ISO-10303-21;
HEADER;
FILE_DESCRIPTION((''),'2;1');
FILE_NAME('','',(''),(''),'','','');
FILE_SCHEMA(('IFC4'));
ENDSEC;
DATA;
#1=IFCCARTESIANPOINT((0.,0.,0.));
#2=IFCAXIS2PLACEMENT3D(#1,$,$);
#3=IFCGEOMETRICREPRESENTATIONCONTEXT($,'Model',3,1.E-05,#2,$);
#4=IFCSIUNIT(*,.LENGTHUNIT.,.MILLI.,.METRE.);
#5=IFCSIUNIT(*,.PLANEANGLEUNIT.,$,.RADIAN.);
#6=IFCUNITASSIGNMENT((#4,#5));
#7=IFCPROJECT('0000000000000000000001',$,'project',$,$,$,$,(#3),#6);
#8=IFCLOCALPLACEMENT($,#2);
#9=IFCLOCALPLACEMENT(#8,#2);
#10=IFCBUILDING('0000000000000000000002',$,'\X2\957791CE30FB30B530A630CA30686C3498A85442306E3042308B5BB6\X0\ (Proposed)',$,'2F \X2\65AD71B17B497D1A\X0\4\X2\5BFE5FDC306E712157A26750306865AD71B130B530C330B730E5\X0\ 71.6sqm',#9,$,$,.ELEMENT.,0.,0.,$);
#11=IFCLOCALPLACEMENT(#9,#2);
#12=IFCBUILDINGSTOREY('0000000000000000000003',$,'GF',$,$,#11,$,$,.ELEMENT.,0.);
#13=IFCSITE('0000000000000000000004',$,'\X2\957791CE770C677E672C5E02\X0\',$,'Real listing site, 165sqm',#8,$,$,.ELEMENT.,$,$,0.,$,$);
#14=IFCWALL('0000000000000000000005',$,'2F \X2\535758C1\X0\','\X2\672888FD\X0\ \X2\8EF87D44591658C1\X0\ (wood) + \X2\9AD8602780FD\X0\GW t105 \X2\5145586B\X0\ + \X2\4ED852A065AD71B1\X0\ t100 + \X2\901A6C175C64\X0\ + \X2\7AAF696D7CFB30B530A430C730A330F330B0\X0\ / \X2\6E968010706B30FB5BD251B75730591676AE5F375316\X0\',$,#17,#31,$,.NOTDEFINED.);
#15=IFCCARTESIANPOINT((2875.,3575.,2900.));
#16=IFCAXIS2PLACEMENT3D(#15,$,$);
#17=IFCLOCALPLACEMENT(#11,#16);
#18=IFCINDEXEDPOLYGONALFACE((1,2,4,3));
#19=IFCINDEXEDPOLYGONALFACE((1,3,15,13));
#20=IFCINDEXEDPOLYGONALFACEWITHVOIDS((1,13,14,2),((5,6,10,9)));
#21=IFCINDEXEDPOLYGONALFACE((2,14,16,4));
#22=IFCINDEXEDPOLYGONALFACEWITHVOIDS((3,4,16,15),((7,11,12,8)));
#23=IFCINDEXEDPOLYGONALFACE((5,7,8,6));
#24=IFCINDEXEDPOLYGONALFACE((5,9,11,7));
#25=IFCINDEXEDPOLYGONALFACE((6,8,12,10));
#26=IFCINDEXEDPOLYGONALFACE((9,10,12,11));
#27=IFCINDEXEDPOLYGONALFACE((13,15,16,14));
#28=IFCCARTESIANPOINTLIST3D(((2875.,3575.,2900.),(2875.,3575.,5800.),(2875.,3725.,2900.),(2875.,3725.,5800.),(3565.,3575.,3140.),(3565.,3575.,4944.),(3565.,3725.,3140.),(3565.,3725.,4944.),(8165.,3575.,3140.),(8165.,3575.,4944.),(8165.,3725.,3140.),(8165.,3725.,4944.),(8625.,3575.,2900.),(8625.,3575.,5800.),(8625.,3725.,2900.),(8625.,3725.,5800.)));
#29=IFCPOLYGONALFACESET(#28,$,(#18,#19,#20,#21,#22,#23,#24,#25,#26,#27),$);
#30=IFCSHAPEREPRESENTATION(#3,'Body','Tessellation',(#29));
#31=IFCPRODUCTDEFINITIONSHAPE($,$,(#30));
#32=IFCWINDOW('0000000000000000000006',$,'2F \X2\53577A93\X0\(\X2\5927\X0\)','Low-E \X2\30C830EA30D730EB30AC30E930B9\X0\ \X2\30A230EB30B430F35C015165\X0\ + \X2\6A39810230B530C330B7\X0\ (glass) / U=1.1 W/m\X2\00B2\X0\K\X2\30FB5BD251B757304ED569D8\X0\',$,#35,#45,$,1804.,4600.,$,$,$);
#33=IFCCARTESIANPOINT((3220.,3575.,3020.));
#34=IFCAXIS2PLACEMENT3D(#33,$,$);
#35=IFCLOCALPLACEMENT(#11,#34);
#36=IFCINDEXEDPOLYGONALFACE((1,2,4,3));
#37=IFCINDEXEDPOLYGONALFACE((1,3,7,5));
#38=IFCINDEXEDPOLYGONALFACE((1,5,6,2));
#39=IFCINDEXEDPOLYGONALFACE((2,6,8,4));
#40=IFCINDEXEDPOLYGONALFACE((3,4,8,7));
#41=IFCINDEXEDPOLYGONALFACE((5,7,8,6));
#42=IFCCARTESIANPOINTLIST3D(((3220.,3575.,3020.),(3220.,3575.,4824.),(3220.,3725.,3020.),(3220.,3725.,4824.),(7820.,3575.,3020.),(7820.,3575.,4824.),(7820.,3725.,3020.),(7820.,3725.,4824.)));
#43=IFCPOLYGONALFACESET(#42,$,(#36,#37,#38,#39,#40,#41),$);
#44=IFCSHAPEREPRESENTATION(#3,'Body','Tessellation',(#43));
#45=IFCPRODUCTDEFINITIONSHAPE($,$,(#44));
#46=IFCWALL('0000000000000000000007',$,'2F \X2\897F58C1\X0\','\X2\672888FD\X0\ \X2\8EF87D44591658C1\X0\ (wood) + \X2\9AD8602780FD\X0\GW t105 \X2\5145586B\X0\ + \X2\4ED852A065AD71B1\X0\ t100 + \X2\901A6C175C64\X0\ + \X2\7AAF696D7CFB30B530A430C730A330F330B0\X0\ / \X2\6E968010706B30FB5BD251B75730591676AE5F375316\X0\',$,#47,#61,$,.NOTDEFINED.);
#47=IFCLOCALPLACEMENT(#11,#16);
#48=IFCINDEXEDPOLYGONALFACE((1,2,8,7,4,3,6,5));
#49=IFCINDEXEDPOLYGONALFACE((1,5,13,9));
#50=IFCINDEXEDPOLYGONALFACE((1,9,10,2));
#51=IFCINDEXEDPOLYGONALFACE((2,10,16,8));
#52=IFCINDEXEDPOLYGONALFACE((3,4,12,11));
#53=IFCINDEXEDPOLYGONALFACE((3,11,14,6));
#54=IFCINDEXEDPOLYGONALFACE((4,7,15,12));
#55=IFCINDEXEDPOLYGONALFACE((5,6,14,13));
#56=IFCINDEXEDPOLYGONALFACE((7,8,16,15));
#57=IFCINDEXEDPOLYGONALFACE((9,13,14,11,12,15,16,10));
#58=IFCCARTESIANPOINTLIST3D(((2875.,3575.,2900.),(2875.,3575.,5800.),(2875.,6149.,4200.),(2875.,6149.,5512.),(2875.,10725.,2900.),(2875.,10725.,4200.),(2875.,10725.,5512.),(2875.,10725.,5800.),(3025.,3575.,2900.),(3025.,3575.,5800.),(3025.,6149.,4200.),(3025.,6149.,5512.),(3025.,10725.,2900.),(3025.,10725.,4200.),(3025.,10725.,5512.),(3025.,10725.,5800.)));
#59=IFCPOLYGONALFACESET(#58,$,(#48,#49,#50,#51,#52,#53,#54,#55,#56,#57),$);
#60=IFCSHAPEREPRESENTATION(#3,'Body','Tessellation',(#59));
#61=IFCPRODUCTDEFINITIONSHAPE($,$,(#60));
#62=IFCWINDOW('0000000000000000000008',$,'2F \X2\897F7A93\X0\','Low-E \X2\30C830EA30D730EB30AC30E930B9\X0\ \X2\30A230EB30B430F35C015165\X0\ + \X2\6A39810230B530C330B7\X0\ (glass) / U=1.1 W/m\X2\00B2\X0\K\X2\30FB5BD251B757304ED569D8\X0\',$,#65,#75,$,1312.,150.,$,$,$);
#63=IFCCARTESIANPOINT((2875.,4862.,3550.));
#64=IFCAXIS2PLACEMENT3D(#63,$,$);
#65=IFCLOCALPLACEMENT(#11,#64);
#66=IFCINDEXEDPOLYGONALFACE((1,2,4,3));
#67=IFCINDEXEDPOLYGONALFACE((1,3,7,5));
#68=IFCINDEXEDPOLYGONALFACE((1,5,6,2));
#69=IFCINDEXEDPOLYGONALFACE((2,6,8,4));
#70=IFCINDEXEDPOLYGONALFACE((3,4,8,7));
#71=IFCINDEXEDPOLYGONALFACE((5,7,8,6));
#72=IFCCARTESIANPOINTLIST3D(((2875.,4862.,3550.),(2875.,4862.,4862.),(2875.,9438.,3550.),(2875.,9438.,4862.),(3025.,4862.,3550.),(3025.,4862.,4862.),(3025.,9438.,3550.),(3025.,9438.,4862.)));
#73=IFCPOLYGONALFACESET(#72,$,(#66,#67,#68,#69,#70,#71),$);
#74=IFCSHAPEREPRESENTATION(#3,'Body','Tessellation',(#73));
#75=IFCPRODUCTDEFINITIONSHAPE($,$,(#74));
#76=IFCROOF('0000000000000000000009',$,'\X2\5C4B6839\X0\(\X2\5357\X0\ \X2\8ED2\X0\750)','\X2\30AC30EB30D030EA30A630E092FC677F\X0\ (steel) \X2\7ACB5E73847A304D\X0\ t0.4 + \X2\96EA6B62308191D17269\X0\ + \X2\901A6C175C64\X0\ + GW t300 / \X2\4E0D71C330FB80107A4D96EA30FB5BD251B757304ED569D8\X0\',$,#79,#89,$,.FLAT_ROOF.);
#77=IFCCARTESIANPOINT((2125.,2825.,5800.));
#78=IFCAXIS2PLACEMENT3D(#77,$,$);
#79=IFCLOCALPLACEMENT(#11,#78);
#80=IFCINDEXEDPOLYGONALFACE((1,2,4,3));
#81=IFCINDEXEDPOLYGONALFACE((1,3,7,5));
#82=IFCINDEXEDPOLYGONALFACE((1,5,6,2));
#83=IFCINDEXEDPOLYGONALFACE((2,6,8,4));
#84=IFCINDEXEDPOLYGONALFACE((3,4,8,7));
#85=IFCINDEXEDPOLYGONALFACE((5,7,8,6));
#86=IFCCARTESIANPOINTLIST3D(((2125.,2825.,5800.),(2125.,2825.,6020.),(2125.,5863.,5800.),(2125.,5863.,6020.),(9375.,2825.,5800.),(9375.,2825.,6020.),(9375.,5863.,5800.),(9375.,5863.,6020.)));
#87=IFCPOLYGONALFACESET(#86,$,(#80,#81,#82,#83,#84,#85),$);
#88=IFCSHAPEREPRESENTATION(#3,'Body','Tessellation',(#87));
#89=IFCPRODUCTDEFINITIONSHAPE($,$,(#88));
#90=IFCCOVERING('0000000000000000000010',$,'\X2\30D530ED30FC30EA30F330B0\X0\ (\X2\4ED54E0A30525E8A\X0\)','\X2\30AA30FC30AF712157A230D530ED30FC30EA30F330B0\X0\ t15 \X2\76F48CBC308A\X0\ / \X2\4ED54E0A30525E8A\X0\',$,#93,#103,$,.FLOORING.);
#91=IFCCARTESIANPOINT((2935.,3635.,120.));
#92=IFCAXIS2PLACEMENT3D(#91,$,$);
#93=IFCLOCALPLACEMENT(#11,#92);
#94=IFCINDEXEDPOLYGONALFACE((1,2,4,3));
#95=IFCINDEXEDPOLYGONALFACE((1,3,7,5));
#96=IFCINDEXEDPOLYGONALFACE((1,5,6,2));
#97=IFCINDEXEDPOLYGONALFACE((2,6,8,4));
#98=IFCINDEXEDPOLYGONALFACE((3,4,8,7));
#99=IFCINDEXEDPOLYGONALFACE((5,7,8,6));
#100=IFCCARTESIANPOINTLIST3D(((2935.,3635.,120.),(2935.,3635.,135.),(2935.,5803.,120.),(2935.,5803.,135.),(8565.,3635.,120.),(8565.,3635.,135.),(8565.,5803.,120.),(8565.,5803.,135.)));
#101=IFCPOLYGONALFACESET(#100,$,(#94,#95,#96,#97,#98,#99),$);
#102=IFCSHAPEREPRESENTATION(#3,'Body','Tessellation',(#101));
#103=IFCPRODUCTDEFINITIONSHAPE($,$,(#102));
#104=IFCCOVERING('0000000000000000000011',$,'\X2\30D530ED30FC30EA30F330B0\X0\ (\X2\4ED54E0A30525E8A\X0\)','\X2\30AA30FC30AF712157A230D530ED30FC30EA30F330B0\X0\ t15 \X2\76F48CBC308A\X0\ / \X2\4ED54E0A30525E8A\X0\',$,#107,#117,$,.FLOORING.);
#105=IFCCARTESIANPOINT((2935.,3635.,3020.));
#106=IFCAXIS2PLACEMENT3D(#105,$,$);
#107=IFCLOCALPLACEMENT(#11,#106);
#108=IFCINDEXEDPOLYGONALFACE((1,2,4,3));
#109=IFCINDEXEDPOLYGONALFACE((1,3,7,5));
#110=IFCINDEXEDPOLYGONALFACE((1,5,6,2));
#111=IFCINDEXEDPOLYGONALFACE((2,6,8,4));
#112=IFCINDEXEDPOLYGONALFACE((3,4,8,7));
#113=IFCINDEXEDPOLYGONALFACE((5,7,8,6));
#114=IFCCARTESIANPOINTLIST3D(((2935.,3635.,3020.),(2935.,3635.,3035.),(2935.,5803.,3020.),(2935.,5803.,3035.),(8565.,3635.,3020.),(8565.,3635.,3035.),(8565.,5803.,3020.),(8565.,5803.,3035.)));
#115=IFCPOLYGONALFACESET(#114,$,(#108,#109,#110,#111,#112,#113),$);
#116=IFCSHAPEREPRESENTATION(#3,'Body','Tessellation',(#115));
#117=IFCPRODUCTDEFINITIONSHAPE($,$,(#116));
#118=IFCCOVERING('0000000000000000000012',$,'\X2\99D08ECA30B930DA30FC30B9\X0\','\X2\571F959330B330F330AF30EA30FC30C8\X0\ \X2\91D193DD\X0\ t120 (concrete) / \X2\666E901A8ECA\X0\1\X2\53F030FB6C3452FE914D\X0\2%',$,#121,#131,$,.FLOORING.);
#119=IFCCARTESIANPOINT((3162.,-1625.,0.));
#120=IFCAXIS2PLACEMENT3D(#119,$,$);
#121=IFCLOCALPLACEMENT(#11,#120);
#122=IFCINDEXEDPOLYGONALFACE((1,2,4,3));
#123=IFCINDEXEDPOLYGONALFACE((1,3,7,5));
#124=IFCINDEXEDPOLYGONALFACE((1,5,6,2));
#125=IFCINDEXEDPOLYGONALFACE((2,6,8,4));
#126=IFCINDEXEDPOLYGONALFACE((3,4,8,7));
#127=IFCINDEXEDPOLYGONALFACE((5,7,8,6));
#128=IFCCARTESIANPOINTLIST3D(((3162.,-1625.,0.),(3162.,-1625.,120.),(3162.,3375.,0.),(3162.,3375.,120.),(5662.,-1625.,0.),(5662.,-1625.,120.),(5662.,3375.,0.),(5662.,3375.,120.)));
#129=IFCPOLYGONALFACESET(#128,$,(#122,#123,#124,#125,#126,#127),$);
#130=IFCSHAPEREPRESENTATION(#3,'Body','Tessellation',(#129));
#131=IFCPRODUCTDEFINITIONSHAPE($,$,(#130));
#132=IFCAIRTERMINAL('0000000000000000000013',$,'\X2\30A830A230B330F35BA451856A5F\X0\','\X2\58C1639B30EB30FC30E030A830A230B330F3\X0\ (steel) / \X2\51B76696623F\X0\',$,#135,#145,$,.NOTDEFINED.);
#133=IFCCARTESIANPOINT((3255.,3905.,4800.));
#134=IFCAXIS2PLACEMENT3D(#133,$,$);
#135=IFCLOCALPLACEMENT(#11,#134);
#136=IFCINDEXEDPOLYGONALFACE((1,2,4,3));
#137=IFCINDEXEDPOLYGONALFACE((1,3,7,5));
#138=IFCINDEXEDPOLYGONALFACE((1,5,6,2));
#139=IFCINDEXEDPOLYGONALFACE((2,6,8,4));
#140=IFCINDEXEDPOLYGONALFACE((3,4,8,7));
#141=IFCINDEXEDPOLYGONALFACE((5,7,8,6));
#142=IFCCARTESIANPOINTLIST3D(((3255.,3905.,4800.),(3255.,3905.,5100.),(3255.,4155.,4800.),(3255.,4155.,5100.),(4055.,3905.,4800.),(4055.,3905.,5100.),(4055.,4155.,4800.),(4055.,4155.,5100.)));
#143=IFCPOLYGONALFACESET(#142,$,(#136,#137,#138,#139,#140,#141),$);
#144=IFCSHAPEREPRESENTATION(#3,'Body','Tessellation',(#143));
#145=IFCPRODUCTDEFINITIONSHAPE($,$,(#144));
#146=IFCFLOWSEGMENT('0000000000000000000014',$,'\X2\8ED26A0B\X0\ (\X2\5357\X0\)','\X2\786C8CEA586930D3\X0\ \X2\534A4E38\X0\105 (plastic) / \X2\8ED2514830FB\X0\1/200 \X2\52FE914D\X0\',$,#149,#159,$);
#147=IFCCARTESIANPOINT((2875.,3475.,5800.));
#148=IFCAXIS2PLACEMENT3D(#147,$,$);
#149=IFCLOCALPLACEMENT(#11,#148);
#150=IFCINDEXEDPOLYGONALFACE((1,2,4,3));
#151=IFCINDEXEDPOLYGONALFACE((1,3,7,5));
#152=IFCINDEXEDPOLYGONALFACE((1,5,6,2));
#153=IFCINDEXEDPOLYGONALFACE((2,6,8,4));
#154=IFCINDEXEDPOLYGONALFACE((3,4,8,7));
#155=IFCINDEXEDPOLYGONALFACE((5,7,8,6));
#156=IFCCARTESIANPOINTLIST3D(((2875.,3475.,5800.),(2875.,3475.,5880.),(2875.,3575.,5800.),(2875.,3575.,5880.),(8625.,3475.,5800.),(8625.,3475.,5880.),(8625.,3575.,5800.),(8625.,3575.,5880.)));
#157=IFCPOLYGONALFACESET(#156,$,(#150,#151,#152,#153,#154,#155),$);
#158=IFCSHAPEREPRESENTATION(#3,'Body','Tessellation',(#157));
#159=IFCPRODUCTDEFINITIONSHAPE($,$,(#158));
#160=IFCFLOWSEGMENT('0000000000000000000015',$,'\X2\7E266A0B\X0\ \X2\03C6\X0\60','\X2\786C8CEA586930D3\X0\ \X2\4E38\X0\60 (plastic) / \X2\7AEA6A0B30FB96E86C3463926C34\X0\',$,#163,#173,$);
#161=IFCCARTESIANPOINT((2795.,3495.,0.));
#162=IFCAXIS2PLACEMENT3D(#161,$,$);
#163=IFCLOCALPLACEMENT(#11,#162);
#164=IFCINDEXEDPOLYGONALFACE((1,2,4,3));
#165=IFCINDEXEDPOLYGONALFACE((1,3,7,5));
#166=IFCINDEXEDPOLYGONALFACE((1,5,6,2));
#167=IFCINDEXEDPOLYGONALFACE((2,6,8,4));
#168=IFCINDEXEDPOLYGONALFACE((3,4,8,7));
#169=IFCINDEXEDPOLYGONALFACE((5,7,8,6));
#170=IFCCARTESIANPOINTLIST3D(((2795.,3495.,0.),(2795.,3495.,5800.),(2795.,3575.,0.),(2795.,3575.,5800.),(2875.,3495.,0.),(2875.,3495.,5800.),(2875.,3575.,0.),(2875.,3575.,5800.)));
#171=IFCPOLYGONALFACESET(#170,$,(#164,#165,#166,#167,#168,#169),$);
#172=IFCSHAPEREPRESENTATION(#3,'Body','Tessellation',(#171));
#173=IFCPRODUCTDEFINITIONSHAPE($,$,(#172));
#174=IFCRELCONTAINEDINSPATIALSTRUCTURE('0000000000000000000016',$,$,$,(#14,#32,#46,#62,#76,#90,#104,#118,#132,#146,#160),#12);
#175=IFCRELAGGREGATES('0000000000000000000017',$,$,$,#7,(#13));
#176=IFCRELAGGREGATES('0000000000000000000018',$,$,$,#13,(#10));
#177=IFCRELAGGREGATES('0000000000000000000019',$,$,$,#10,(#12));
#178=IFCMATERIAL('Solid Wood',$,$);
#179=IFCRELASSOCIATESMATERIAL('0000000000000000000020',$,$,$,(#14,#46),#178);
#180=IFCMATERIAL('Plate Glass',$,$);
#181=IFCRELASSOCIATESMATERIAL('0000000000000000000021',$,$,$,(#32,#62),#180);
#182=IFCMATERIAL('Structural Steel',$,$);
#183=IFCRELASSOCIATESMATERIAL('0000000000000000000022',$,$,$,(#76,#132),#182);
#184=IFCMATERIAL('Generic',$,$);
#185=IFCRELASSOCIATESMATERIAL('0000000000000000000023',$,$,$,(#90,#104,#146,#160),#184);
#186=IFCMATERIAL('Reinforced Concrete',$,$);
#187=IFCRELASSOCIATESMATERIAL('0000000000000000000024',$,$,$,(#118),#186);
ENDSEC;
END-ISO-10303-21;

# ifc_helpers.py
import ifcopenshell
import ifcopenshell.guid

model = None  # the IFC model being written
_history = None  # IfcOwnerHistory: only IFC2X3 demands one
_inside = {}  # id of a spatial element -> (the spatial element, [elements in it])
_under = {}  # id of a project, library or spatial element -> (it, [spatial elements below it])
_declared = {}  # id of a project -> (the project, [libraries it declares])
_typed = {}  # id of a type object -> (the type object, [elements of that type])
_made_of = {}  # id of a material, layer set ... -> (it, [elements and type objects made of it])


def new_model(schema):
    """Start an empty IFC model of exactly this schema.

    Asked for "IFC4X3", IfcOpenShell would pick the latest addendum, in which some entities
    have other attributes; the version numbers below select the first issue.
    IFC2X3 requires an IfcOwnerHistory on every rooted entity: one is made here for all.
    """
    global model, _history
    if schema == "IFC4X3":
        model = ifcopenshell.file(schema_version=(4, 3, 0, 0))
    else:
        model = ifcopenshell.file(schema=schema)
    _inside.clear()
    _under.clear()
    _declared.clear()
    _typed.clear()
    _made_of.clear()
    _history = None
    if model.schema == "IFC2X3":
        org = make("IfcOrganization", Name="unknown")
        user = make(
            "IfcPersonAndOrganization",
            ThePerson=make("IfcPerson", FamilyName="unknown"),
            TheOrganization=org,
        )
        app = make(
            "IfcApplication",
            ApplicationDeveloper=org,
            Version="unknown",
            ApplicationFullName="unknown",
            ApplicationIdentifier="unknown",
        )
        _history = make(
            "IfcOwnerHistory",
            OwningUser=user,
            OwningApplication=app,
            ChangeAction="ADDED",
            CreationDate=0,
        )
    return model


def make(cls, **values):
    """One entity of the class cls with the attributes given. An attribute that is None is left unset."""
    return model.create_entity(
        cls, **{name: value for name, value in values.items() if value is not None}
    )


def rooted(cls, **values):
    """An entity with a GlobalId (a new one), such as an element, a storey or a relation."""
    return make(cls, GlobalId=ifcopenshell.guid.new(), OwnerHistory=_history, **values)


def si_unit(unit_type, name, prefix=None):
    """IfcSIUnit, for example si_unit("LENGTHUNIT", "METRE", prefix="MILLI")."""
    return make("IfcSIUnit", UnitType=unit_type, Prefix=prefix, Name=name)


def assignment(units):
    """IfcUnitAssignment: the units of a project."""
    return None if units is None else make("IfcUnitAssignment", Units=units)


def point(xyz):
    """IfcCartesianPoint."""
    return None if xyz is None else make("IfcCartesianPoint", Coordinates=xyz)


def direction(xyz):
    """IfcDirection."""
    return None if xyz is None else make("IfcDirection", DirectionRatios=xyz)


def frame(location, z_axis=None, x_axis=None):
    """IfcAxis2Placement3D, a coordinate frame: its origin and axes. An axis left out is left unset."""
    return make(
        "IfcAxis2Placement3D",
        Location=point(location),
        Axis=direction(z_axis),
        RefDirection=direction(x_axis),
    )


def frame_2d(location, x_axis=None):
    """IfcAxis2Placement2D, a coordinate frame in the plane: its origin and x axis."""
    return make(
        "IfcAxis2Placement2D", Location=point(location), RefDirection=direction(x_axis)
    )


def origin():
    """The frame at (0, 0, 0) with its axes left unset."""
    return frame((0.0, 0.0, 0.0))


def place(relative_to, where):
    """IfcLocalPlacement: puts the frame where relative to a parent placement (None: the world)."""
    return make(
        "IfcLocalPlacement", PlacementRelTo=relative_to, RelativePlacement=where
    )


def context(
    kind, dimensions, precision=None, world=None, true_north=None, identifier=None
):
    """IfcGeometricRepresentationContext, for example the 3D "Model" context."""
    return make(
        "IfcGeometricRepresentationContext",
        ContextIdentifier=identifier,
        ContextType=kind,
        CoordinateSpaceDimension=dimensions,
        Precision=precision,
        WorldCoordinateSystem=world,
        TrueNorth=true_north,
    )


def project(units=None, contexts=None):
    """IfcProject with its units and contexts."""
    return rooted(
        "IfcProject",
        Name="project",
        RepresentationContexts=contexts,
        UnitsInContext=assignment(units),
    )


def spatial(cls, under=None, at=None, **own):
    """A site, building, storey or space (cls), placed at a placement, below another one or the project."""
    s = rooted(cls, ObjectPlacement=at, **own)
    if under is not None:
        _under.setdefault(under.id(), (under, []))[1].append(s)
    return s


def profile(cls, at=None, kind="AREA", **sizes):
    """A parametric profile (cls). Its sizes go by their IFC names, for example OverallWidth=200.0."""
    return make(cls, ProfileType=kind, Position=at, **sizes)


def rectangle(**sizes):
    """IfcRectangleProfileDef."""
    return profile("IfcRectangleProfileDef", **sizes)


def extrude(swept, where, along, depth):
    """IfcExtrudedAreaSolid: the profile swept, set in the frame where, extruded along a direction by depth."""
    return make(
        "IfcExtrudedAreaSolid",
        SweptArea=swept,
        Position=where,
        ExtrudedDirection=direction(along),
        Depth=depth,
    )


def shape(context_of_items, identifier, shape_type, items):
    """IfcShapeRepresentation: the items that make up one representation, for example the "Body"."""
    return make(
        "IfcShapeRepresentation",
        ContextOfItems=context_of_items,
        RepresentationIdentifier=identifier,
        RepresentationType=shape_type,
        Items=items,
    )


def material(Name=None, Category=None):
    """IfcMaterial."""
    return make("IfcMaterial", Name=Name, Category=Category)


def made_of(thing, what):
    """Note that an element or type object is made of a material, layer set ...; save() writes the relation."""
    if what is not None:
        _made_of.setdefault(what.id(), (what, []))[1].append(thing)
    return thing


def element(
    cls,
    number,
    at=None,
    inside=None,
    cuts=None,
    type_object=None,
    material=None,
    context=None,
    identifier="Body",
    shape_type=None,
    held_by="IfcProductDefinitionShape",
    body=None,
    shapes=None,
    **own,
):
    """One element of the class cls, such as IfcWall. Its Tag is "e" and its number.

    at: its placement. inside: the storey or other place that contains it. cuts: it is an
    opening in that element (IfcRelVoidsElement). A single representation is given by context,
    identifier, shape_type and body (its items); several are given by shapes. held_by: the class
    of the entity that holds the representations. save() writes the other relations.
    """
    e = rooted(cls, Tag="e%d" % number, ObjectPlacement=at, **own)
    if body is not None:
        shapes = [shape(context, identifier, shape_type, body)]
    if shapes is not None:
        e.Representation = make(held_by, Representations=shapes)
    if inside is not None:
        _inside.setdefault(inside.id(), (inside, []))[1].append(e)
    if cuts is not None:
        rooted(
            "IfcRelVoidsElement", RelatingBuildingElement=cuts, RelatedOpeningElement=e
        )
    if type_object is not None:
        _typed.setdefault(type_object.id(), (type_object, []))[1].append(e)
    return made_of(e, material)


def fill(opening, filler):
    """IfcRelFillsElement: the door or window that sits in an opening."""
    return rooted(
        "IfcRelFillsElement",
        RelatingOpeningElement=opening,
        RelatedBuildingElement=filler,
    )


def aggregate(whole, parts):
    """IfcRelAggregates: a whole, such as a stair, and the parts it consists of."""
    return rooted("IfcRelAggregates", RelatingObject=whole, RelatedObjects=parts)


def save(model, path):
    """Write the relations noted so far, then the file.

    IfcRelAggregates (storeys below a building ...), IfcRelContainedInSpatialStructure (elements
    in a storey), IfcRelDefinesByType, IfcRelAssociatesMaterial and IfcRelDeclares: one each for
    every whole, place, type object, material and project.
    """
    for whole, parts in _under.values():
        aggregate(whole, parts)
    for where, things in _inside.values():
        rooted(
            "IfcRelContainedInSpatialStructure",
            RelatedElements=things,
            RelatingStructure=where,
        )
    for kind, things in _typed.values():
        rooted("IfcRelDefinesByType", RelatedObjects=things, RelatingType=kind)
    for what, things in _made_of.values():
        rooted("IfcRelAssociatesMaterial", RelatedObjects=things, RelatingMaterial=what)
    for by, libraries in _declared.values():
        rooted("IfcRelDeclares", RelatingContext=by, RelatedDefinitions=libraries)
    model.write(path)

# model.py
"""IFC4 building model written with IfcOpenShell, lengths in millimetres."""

from ifc_helpers import new_model, si_unit, frame, frame_2d, origin, place, context, project, spatial, rectangle, extrude, material, element, fill, save


model = new_model("IFC4")

# Units and contexts
model_context = context("Model", 3, precision=1e-05, world=origin())
ifc_project = project(units=[si_unit("LENGTHUNIT", "METRE", prefix="MILLI"), si_unit("PLANEANGLEUNIT", "RADIAN")], contexts=[model_context])

# Site, building, storey
site_placement = place(None, origin())
site = spatial("IfcSite", under=ifc_project, at=site_placement, Name="長野県松本市", ObjectType="Real listing site, 165sqm", CompositionType="ELEMENT", RefElevation=0.0)
building_placement = place(site_placement, origin())
building = spatial("IfcBuilding", under=site, at=building_placement, Name="長野・サウナと水風呂のある家 (Proposed)", ObjectType="2F 断熱等級4対応の無垢材と断熱サッシュ 71.6sqm", CompositionType="ELEMENT", ElevationOfRefHeight=0.0, ElevationOfTerrain=0.0)
storey_placement = place(building_placement, origin())
storey = spatial("IfcBuildingStorey", under=building, at=storey_placement, Name="GF", CompositionType="ELEMENT", Elevation=0.0)

# Shared definitions
ifc_material_1 = material(Name="Solid Wood")

# Shared definitions
ifc_material_2 = material(Name="Reinforced Concrete")

# Shared definitions
ifc_material_3 = material(Name="Plate Glass")

# Walls, openings, windows
wall_1_placement = place(storey_placement, frame((2875.0, 3575.0, 2900.0)))
wall_1 = element("IfcWall", 1, at=wall_1_placement, inside=storey, material=ifc_material_1, Name="2F 南壁", Description="木製 軸組外壁 (wood) + 高性能GW t105 充填 + 付加断熱 t100 + 通気層 + 窯業系サイディング / 準耐火・寒冷地外皮強化", PredefinedType="NOTDEFINED", context=model_context, shape_type="SweptSolid", body=[
    extrude(rectangle(XDim=5750.0, YDim=150.0, at=frame_2d((2875.0, 75.0))), frame((2875.0, 3575.0, 2900.0)), (0.0, 0.0, 1.0), 2900.0),
])
opening_1_placement = place(storey_placement, frame((3220.0, 3575.0, 3020.0)))
opening_1 = element("IfcOpeningElement", 2, at=opening_1_placement, cuts=wall_1, PredefinedType="NOTDEFINED", context=model_context, shape_type="SweptSolid", body=[
    extrude(rectangle(XDim=4600.0, YDim=150.0, at=frame_2d((2300.0, 75.0))), frame((3220.0, 3575.0, 3020.0)), (0.0, 0.0, 1.0), 1804.0),
])
window_1_placement = place(storey_placement, frame((3220.0, 3575.0, 3020.0)))
window_1 = element("IfcWindow", 3, at=window_1_placement, inside=storey, material=ifc_material_3, Name="2F 南窓(大)", Description="Low-E トリプルガラス アルゴン封入 + 樹脂サッシ (glass) / U=1.1 W/m²K・寒冷地仕様", OverallHeight=1804.0, OverallWidth=4600.0, context=model_context, shape_type="SweptSolid", body=[
    extrude(rectangle(XDim=4600.0, YDim=150.0, at=frame_2d((2300.0, 75.0))), frame((3220.0, 3575.0, 3020.0)), (0.0, 0.0, 1.0), 1804.0),
])
fill(opening_1, window_1)
wall_2_placement = place(storey_placement, frame((2875.0, 3575.0, 2900.0)))
wall_2 = element("IfcWall", 4, at=wall_2_placement, inside=storey, material=ifc_material_1, Name="2F 西壁", Description="木製 軸組外壁 (wood) + 高性能GW t105 充填 + 付加断熱 t100 + 通気層 + 窯業系サイディング / 準耐火・寒冷地外皮強化", PredefinedType="NOTDEFINED", context=model_context, shape_type="SweptSolid", body=[
    extrude(rectangle(XDim=150.0, YDim=7150.0, at=frame_2d((75.0, 3575.0))), frame((2875.0, 3575.0, 2900.0)), (0.0, 0.0, 1.0), 2900.0),
])
opening_2_placement = place(storey_placement, frame((2875.0, 4862.0, 3550.0)))
opening_2 = element("IfcOpeningElement", 5, at=opening_2_placement, cuts=wall_2, PredefinedType="NOTDEFINED", context=model_context, shape_type="SweptSolid", body=[
    extrude(rectangle(XDim=150.0, YDim=4576.0, at=frame_2d((75.0, 2288.0))), frame((2875.0, 4862.0, 3550.0)), (0.0, 0.0, 1.0), 1312.0),
])
window_2_placement = place(storey_placement, frame((2875.0, 4862.0, 3550.0)))
window_2 = element("IfcWindow", 6, at=window_2_placement, inside=storey, material=ifc_material_3, Name="2F 西窓", Description="Low-E トリプルガラス アルゴン封入 + 樹脂サッシ (glass) / U=1.1 W/m²K・寒冷地仕様", OverallHeight=1312.0, OverallWidth=150.0, context=model_context, shape_type="SweptSolid", body=[
    extrude(rectangle(XDim=150.0, YDim=4576.0, at=frame_2d((75.0, 2288.0))), frame((2875.0, 4862.0, 3550.0)), (0.0, 0.0, 1.0), 1312.0),
])
fill(opening_2, window_2)

# Roof
ifc_material_4 = material(Name="Structural Steel")
for number, where, name in (
    (7, (2125.0, 2825.0, 5800.0), "屋根(南 軒750)"),
):
    element("IfcRoof", number, at=place(storey_placement, frame(where)), inside=storey, material=ifc_material_4, Name=name, Description="ガルバリウム鋼板 (steel) 立平葺き t0.4 + 雪止め金物 + 通気層 + GW t300 / 不燃・耐積雪・寒冷地仕様", PredefinedType="FLAT_ROOF", context=model_context, shape_type="SweptSolid", body=[
        extrude(rectangle(XDim=7250.0, YDim=3038.0, at=frame_2d((3625.0, 1519.0))), frame((2125.0, 2825.0, 5800.0)), (0.0, 0.0, 1.0), 220.0),
    ])

# Coverings
ifc_material_5 = material(Name="Generic")
covering_1_placement = place(storey_placement, frame((2935.0, 3635.0, 120.0)))
element("IfcCovering", 8, at=covering_1_placement, inside=storey, material=ifc_material_5, Name="フローリング (仕上げ床)", Description="オーク無垢フローリング t15 直貼り / 仕上げ床", PredefinedType="FLOORING", context=model_context, shape_type="SweptSolid", body=[
    extrude(rectangle(XDim=5630.0, YDim=2168.0, at=frame_2d((2815.0, 1084.0))), frame((2935.0, 3635.0, 120.0)), (0.0, 0.0, 1.0), 15.0),
])
covering_2_placement = place(storey_placement, frame((2935.0, 3635.0, 3020.0)))
element("IfcCovering", 9, at=covering_2_placement, inside=storey, material=ifc_material_5, Name="フローリング (仕上げ床)", Description="オーク無垢フローリング t15 直貼り / 仕上げ床", PredefinedType="FLOORING", context=model_context, shape_type="SweptSolid", body=[
    extrude(rectangle(XDim=5630.0, YDim=2168.0, at=frame_2d((2815.0, 1084.0))), frame((2935.0, 3635.0, 3020.0)), (0.0, 0.0, 1.0), 15.0),
])
covering_3_placement = place(storey_placement, frame((3162.0, -1625.0, 0.0)))
element("IfcCovering", 10, at=covering_3_placement, inside=storey, material=ifc_material_2, Name="駐車スペース", Description="土間コンクリート 金鏝 t120 (concrete) / 普通車1台・水勾配2%", PredefinedType="FLOORING", context=model_context, shape_type="SweptSolid", body=[
    extrude(rectangle(XDim=2500.0, YDim=5000.0, at=frame_2d((1250.0, 2500.0))), frame((3162.0, -1625.0, 0.0)), (0.0, 0.0, 1.0), 120.0),
])

# Air terminal
air_terminal_placement = place(storey_placement, frame((3255.0, 3905.0, 4800.0)))
element("IfcAirTerminal", 11, at=air_terminal_placement, inside=storey, material=ifc_material_4, Name="エアコン室内機", Description="壁掛ルームエアコン (steel) / 冷暖房", PredefinedType="NOTDEFINED", context=model_context, shape_type="SweptSolid", body=[
    extrude(rectangle(XDim=800.0, YDim=250.0, at=frame_2d((400.0, 125.0))), frame((3255.0, 3905.0, 4800.0)), (0.0, 0.0, 1.0), 300.0),
])

# Flow segments
flow_segment_1_placement = place(storey_placement, frame((2875.0, 3475.0, 5800.0)))
element("IfcFlowSegment", 12, at=flow_segment_1_placement, inside=storey, material=ifc_material_5, Name="軒樋 (南)", Description="硬質塩ビ 半丸105 (plastic) / 軒先・1/200 勾配", context=model_context, shape_type="SweptSolid", body=[
    extrude(rectangle(XDim=5750.0, YDim=100.0, at=frame_2d((2875.0, 50.0))), frame((2875.0, 3475.0, 5800.0)), (0.0, 0.0, 1.0), 80.0),
])
flow_segment_2_placement = place(storey_placement, frame((2795.0, 3495.0, 0.0)))
element("IfcFlowSegment", 13, at=flow_segment_2_placement, inside=storey, material=ifc_material_5, Name="縦樋 φ60", Description="硬質塩ビ 丸60 (plastic) / 竪樋・雨水排水", context=model_context, shape_type="SweptSolid", body=[
    extrude(rectangle(XDim=80.0, YDim=80.0, at=frame_2d((40.0, 40.0))), frame((2795.0, 3495.0, 0.0)), (0.0, 0.0, 1.0), 5800.0),
])

save(model, "model.ifc")
